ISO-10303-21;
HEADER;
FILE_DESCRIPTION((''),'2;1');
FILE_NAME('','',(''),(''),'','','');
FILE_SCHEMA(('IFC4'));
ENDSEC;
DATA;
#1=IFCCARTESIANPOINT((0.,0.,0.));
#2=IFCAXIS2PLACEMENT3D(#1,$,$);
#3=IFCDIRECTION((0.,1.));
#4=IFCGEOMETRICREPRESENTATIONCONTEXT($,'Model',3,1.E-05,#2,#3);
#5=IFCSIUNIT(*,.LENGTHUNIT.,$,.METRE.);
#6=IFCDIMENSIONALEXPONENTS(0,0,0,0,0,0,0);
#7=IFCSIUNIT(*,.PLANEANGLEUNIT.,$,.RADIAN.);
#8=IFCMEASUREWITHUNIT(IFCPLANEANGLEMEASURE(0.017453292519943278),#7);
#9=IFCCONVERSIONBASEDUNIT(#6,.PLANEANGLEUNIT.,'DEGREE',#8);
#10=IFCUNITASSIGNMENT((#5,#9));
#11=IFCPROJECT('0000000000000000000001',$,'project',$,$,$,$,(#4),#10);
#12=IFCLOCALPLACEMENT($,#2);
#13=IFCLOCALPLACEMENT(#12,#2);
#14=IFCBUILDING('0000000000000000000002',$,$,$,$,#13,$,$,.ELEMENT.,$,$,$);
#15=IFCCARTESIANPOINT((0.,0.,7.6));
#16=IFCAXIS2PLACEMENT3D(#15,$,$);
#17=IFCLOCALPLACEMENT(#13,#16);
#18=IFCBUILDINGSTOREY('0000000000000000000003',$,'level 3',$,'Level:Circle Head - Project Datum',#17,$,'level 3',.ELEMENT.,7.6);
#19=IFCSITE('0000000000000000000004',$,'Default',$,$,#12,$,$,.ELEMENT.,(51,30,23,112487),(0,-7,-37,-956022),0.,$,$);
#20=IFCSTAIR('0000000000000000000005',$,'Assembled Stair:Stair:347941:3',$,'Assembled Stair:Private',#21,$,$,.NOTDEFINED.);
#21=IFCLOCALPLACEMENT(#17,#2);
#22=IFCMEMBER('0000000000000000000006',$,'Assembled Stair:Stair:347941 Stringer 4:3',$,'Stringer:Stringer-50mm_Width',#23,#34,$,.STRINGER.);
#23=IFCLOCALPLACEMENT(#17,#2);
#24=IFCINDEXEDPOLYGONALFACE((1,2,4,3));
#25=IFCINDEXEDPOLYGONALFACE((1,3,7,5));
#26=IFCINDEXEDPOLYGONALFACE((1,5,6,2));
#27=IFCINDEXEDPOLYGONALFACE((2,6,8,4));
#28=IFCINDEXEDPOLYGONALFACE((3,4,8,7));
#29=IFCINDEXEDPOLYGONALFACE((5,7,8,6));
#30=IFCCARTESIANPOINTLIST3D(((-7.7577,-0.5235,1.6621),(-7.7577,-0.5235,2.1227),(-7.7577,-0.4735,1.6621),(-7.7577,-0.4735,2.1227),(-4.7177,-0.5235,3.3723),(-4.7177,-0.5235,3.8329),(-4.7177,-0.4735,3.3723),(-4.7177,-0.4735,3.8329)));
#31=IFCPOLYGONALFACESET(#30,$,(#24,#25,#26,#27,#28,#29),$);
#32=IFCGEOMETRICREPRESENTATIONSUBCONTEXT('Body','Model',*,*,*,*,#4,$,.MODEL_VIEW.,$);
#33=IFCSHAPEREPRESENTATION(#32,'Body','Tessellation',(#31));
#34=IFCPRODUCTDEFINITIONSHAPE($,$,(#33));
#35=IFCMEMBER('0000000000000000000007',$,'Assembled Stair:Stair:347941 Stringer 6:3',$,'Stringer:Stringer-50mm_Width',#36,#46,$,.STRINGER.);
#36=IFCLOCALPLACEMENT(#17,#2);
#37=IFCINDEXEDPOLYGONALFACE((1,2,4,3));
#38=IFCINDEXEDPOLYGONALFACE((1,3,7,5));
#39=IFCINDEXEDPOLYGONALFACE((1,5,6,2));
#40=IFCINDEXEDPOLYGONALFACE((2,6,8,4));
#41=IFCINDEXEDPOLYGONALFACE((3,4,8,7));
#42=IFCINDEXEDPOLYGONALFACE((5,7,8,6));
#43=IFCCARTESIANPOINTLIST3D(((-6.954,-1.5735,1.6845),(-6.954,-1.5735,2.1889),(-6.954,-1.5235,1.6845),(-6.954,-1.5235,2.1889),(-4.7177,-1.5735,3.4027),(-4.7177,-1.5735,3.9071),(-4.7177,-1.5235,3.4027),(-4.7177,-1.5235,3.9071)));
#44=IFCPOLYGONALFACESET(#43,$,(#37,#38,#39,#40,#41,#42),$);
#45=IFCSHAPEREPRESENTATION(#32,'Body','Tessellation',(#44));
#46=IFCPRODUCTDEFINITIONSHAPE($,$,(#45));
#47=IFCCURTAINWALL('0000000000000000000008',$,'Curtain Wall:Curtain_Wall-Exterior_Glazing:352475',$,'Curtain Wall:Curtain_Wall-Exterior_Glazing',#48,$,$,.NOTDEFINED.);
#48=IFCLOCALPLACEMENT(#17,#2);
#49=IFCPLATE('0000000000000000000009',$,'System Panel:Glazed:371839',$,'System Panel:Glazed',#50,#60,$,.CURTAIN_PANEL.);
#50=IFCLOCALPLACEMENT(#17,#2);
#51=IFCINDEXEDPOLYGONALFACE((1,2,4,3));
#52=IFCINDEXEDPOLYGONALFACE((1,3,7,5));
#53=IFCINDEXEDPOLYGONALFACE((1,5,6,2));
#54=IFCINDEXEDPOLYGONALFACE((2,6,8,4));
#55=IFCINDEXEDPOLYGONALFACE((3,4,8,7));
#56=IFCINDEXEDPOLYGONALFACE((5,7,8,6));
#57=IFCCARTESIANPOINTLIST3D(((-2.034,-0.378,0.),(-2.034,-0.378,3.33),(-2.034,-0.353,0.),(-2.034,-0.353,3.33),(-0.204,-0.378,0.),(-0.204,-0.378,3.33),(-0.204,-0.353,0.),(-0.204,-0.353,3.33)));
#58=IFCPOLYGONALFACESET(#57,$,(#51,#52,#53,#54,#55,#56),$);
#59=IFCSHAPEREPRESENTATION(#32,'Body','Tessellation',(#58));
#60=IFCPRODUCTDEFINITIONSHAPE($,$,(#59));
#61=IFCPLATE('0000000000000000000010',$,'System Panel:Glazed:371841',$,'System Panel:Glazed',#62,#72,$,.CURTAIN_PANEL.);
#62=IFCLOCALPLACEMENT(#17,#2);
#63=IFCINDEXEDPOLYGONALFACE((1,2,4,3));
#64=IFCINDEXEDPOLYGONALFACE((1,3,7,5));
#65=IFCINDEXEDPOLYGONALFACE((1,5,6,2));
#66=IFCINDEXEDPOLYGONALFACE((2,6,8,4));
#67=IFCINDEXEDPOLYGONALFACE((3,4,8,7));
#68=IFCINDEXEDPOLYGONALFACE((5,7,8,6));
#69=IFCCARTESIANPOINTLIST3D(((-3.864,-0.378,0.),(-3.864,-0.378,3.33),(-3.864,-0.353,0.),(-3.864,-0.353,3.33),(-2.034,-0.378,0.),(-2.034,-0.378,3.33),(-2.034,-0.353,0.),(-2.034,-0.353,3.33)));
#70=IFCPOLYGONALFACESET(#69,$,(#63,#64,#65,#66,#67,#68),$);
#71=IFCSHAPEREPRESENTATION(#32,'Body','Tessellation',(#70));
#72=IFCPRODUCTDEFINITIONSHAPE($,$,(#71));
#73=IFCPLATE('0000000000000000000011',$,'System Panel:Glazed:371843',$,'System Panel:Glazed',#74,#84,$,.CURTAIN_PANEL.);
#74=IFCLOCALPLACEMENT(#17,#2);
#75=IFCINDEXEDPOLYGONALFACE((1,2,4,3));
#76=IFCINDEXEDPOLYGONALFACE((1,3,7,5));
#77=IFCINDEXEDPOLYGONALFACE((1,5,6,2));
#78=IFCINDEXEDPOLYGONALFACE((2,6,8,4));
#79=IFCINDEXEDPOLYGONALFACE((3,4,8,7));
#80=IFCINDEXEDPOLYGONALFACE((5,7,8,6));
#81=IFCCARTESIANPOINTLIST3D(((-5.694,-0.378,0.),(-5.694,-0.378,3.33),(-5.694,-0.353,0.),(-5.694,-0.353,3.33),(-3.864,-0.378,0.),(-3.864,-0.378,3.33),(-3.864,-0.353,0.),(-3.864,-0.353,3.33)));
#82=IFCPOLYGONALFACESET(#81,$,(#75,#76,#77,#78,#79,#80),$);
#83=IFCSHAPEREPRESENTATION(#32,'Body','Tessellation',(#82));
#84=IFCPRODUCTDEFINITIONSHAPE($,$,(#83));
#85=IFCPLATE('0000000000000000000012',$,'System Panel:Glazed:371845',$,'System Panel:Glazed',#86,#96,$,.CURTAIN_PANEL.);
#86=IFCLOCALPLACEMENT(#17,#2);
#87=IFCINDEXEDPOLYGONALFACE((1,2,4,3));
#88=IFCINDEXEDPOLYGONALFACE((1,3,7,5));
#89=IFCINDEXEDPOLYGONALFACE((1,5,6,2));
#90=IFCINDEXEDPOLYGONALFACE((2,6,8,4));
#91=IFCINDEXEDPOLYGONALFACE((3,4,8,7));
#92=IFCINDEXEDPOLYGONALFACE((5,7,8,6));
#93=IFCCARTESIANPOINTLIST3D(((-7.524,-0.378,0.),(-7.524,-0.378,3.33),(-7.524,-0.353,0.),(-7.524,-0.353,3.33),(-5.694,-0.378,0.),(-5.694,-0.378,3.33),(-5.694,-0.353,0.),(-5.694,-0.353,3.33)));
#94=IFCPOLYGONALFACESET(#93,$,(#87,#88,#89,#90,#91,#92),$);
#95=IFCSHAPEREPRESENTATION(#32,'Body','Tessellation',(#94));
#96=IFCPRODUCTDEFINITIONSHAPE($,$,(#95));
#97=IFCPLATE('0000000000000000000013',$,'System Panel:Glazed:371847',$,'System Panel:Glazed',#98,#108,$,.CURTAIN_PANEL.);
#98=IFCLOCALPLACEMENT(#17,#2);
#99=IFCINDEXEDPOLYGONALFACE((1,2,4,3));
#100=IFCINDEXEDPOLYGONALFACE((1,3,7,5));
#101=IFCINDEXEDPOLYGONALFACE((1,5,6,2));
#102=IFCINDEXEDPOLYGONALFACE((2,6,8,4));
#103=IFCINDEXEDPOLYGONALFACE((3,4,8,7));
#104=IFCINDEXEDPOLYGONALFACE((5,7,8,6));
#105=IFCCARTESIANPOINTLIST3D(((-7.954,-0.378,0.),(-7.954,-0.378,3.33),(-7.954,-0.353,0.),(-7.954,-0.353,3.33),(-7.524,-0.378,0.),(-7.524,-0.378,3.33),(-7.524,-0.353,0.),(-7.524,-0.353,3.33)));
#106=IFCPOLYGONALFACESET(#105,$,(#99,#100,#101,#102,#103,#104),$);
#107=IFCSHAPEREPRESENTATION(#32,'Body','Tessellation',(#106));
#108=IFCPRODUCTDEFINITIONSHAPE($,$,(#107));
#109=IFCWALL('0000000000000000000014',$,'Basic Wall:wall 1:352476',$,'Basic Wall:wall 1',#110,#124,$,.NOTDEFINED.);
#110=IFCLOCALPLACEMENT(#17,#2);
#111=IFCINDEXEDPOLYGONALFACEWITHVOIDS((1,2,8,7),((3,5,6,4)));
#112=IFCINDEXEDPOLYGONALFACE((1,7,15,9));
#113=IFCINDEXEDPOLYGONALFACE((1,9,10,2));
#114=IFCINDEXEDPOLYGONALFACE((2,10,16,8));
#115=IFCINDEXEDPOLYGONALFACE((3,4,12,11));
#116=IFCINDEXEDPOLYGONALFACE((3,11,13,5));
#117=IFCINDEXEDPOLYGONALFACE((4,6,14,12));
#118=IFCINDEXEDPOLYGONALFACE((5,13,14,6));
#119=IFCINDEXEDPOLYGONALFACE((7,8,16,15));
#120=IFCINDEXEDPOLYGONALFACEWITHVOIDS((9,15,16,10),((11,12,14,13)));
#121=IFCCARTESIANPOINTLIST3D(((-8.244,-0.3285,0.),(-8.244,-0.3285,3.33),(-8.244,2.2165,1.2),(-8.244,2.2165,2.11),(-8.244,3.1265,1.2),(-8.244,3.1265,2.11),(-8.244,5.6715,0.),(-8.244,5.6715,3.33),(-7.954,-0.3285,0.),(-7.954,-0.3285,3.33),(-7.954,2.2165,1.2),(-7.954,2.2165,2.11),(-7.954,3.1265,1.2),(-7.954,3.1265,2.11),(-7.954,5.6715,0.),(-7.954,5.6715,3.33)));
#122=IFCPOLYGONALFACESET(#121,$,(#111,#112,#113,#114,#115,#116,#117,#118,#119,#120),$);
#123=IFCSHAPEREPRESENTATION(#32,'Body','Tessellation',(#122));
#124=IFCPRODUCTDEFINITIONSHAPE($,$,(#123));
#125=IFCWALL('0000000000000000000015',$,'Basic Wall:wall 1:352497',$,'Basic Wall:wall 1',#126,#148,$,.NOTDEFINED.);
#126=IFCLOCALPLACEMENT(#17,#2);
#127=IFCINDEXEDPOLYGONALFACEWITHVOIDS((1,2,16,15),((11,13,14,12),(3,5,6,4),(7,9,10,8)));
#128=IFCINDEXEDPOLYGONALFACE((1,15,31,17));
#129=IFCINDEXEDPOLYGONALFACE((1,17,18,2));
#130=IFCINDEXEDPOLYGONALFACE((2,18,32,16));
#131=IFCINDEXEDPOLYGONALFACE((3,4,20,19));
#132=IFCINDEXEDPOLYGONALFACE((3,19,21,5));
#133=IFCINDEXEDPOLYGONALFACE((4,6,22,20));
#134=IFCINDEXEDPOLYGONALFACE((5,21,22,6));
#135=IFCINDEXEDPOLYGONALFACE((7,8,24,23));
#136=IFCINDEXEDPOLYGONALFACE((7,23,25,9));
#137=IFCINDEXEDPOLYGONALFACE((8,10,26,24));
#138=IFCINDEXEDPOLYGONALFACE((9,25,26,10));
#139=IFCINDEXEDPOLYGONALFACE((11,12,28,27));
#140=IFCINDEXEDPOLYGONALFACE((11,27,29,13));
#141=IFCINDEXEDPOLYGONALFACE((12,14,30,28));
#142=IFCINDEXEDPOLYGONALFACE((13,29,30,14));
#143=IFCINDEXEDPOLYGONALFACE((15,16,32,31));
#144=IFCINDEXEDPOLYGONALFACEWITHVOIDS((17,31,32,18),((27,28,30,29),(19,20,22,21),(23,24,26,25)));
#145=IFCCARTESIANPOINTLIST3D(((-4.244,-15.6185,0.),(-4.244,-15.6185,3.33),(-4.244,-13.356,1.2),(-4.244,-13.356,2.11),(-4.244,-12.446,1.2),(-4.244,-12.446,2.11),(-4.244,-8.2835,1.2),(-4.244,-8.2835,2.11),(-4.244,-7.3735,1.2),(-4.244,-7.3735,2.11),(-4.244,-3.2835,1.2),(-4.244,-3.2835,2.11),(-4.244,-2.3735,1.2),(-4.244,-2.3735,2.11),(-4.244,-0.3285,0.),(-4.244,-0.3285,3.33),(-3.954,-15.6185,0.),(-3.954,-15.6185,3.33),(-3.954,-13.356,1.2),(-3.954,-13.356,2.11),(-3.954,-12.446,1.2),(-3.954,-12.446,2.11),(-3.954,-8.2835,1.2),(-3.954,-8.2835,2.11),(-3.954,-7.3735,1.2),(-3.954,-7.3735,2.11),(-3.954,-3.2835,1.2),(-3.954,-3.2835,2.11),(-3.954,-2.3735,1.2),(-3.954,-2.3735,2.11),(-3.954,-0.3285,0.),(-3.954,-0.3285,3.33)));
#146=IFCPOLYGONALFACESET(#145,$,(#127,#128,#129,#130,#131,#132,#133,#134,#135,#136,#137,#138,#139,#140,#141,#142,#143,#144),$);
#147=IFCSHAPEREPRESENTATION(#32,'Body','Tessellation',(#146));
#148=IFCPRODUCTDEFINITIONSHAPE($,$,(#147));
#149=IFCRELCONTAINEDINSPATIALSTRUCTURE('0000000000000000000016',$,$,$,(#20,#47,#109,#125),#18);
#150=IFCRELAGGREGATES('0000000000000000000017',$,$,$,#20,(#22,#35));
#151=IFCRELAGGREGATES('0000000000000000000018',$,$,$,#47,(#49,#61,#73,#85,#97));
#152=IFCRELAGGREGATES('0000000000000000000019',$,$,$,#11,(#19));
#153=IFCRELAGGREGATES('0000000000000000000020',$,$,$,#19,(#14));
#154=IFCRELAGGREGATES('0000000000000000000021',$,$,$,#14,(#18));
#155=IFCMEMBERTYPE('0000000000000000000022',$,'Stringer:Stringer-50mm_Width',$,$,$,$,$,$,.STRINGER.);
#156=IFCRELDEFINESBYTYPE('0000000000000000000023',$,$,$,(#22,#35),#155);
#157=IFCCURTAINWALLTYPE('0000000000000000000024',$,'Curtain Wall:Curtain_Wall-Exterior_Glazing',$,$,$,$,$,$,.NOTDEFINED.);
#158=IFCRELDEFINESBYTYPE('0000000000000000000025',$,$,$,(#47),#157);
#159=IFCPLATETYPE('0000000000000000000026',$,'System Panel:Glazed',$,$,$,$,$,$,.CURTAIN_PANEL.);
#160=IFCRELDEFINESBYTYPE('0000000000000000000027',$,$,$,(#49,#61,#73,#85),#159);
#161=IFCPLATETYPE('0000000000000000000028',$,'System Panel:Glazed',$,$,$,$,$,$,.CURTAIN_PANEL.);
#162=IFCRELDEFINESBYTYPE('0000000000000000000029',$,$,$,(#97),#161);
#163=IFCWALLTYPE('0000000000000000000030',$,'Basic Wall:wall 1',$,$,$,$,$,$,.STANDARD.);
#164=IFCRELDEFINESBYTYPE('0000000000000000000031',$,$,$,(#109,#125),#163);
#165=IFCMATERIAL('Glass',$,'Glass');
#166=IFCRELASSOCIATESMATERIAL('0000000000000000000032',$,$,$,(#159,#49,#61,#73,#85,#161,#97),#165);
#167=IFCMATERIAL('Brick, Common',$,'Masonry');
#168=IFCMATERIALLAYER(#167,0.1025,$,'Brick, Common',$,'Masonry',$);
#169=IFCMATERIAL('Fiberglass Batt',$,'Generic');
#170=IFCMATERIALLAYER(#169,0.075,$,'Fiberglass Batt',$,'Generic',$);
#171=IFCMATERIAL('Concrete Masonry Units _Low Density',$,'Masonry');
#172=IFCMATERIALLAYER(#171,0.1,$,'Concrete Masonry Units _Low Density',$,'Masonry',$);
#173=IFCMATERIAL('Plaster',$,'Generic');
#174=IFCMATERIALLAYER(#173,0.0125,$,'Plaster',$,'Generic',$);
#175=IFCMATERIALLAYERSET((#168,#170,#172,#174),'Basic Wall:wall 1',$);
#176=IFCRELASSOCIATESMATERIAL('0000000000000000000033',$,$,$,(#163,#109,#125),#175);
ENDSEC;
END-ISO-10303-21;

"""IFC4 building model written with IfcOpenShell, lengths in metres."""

from ifc_helpers import new_model, entity, si_unit, converted_unit, direction, frame, frame_2d, origin, origin_2d_with_axis, place, context, subcontext, project, spatial, polyline, rectangle, outline, extrude, clip, bounded_halfspace, source, transform, mapped, material, layer, layer_set, layer_usage, type_object, type_shapes, element, aggregate, save


model = new_model("IFC4")

# Units and contexts
model_context = context("Model", 3, precision=1e-05, world=origin(), true_north=direction((0.0, 1.0)))
body_context = subcontext(model_context, "Body", "Model", "MODEL_VIEW")
ifc_project = project(units=[si_unit("LENGTHUNIT", "METRE"), converted_unit("PLANEANGLEUNIT", "DEGREE", entity("IfcPlaneAngleMeasure", 0.017453292519943278), si_unit("PLANEANGLEUNIT", "RADIAN"), dimensions=[0, 0, 0, 0, 0, 0, 0])], contexts=[model_context])

# Site, building, storey
site_placement = place(None, origin())
site = spatial("IfcSite", under=ifc_project, at=site_placement, Name="Default", CompositionType="ELEMENT", RefLatitude=(51, 30, 23, 112487), RefLongitude=(0, -7, -37, -956022), RefElevation=0.0)
building_placement = place(site_placement, origin())
building = spatial("IfcBuilding", under=site, at=building_placement, CompositionType="ELEMENT")
storey_placement = place(building_placement, frame((0.0, 0.0, 7.6)))
storey = spatial("IfcBuildingStorey", under=building, at=storey_placement, Name="level 3", ObjectType="Level:Circle Head - Project Datum", LongName="level 3", CompositionType="ELEMENT", Elevation=7.6)

# Stair, members
stair_placement = place(storey_placement, origin())
stair = element("IfcStair", 1, at=stair_placement, inside=storey, Name="Assembled Stair:Stair:347941:3", ObjectType="Assembled Stair:Private", PredefinedType="NOTDEFINED")
member_type = type_object("IfcMemberType", Name="Stringer:Stringer-50mm_Width", PredefinedType="STRINGER")
member_1_placement = place(stair_placement, frame((-7.7577, -0.5235, 1.6621)))
member_1 = element("IfcMember", 2, at=member_1_placement, type_object=member_type, Name="Assembled Stair:Stair:347941 Stringer 4:3", ObjectType="Stringer:Stringer-50mm_Width", PredefinedType="STRINGER", context=body_context, shape_type="SweptSolid", body=[
    extrude(outline(polyline([(-1.6311, -0.2007), (1.857, -0.2007), (1.6311, 0.2007), (-1.857, 0.2007), (-1.6311, -0.2007)])), frame((1.52, 0.0, 1.0854), z_axis=(0.0, 1.0, 0.0), x_axis=(0.871553, 0.0, 0.490302)), (0.0, 0.0, 1.0), 0.05),
])
member_2_placement = place(stair_placement, frame((-6.954, -1.5735, 1.6845)))
member_2 = element("IfcMember", 3, at=member_2_placement, type_object=member_type, Name="Assembled Stair:Stair:347941 Stringer 6:3", ObjectType="Stringer:Stringer-50mm_Width", PredefinedType="STRINGER", context=body_context, shape_type="SweptSolid", body=[
    extrude(outline(polyline([(-1.2564, -0.2), (1.5637, -0.2), (1.2564, 0.2), (-1.5637, 0.2), (-1.2564, -0.2)])), frame((1.1182, 0.0, 1.1113), z_axis=(0.0, 1.0, 0.0), x_axis=(0.792984, 0.0, 0.609242)), (0.0, 0.0, 1.0), 0.05),
])
aggregate(stair, [member_1, member_2])

# Curtain wall, plates
curtain_wall_type = type_object("IfcCurtainWallType", Name="Curtain Wall:Curtain_Wall-Exterior_Glazing", PredefinedType="NOTDEFINED")
curtain_wall_placement = place(storey_placement, frame((0.0, 0.0, -7.6)))
curtain_wall = element("IfcCurtainWall", 4, at=curtain_wall_placement, inside=storey, type_object=curtain_wall_type, Name="Curtain Wall:Curtain_Wall-Exterior_Glazing:352475", ObjectType="Curtain Wall:Curtain_Wall-Exterior_Glazing", PredefinedType="NOTDEFINED")
ifc_material_1 = material(Name="Glass", Category="Glass")
plate_type_1 = type_object("IfcPlateType", Name="System Panel:Glazed", PredefinedType="CURTAIN_PANEL", material=ifc_material_1)
shared_shape_1 = source(origin(), body_context, "Body", "SweptSolid", [
    extrude(rectangle(XDim=0.025, YDim=1.83, at=origin_2d_with_axis()), frame((0.915, 0.0125, 0.0), z_axis=(0.0, 0.0, 1.0), x_axis=(0.0, 1.0, 0.0)), (0.0, 0.0, 1.0), 3.33),
])
type_shapes(plate_type_1, [shared_shape_1])
plate_1_placement = place(curtain_wall_placement, frame((-0.204, -0.353, 7.6), z_axis=(0.0, 0.0, 1.0), x_axis=(-1.0, 0.0, 0.0)))
plate_1 = element("IfcPlate", 5, at=plate_1_placement, type_object=plate_type_1, material=ifc_material_1, Name="System Panel:Glazed:371839", ObjectType="System Panel:Glazed", PredefinedType="CURTAIN_PANEL", context=body_context, shape_type="MappedRepresentation", body=[
    mapped(shared_shape_1, transform((0.0, 0.0, 0.0), scale=1.0)),
])
plate_2_placement = place(curtain_wall_placement, frame((-2.034, -0.353, 7.6), z_axis=(0.0, 0.0, 1.0), x_axis=(-1.0, 0.0, 0.0)))
plate_2 = element("IfcPlate", 6, at=plate_2_placement, type_object=plate_type_1, material=ifc_material_1, Name="System Panel:Glazed:371841", ObjectType="System Panel:Glazed", PredefinedType="CURTAIN_PANEL", context=body_context, shape_type="MappedRepresentation", body=[
    mapped(shared_shape_1, transform((0.0, 0.0, 0.0), scale=1.0)),
])
plate_3_placement = place(curtain_wall_placement, frame((-3.864, -0.353, 7.6), z_axis=(0.0, 0.0, 1.0), x_axis=(-1.0, 0.0, 0.0)))
plate_3 = element("IfcPlate", 7, at=plate_3_placement, type_object=plate_type_1, material=ifc_material_1, Name="System Panel:Glazed:371843", ObjectType="System Panel:Glazed", PredefinedType="CURTAIN_PANEL", context=body_context, shape_type="MappedRepresentation", body=[
    mapped(shared_shape_1, transform((0.0, 0.0, 0.0), scale=1.0)),
])
plate_4_placement = place(curtain_wall_placement, frame((-5.694, -0.353, 7.6), z_axis=(0.0, 0.0, 1.0), x_axis=(-1.0, 0.0, 0.0)))
plate_4 = element("IfcPlate", 8, at=plate_4_placement, type_object=plate_type_1, material=ifc_material_1, Name="System Panel:Glazed:371845", ObjectType="System Panel:Glazed", PredefinedType="CURTAIN_PANEL", context=body_context, shape_type="MappedRepresentation", body=[
    mapped(shared_shape_1, transform((0.0, 0.0, 0.0), scale=1.0)),
])
plate_type_2 = type_object("IfcPlateType", Name="System Panel:Glazed", PredefinedType="CURTAIN_PANEL", material=ifc_material_1)
shared_shape_2 = source(origin(), body_context, "Body", "SweptSolid", [
    extrude(rectangle(XDim=0.025, YDim=0.43, at=origin_2d_with_axis()), frame((0.215, 0.0125, 0.0), z_axis=(0.0, 0.0, 1.0), x_axis=(0.0, 1.0, 0.0)), (0.0, 0.0, 1.0), 3.33),
])
type_shapes(plate_type_2, [shared_shape_2])
plate_5_placement = place(curtain_wall_placement, frame((-7.524, -0.353, 7.6), z_axis=(0.0, 0.0, 1.0), x_axis=(-1.0, 0.0, 0.0)))
plate_5 = element("IfcPlate", 9, at=plate_5_placement, type_object=plate_type_2, material=ifc_material_1, Name="System Panel:Glazed:371847", ObjectType="System Panel:Glazed", PredefinedType="CURTAIN_PANEL", context=body_context, shape_type="MappedRepresentation", body=[
    mapped(shared_shape_2, transform((0.0, 0.0, 0.0), scale=1.0)),
])
aggregate(curtain_wall, [plate_1, plate_2, plate_3, plate_4, plate_5])

# Wall, opening
ifc_material_2 = material(Name="Brick, Common", Category="Masonry")
ifc_layer_1 = layer(ifc_material_2, 0.1025, Name="Brick, Common", Category="Masonry")
ifc_material_3 = material(Name="Fiberglass Batt", Category="Generic")
ifc_layer_2 = layer(ifc_material_3, 0.075, Name="Fiberglass Batt", Category="Generic")
ifc_material_4 = material(Name="Concrete Masonry Units _Low Density", Category="Masonry")
ifc_layer_3 = layer(ifc_material_4, 0.1, Name="Concrete Masonry Units _Low Density", Category="Masonry")
ifc_material_5 = material(Name="Plaster", Category="Generic")
ifc_layer_4 = layer(ifc_material_5, 0.0125, Name="Plaster", Category="Generic")
ifc_layer_set = layer_set([ifc_layer_1, ifc_layer_2, ifc_layer_3, ifc_layer_4], Name="Basic Wall:wall 1")
ifc_layer_usage_1 = layer_usage(ifc_layer_set, "AXIS2", "NEGATIVE", 0.145)
wall_type = type_object("IfcWallType", Name="Basic Wall:wall 1", PredefinedType="STANDARD", material=ifc_layer_set)
wall_1_placement = place(storey_placement, frame((-8.099, -0.3285, 0.0), z_axis=(0.0, 0.0, 1.0), x_axis=(0.0, 1.0, 0.0)))
wall_1 = element("IfcWall", 10, at=wall_1_placement, inside=storey, type_object=wall_type, material=ifc_layer_usage_1, Name="Basic Wall:wall 1:352476", ObjectType="Basic Wall:wall 1", PredefinedType="NOTDEFINED", context=body_context, shape_type="Clipping", body=[
    clip(extrude(rectangle(XDim=6.0, YDim=0.29, at=frame_2d((3.0, 0.0), x_axis=(-1.0, 0.0))), origin(), (0.0, 0.0, 1.0), 3.33), bounded_halfspace(frame((0.0, -0.145, 3.33), z_axis=(0.0, 0.0, -1.0), x_axis=(1.0, 0.0, 0.0)), True, frame((0.0, -0.145, 3.33)), polyline([(0.0, 0.0), (6.0, 0.0), (6.0, 0.29), (0.0, 0.29), (0.0, 0.0)]))),
])
opening_1_placement = place(wall_1_placement, frame((2.545, -0.145, 1.2)))
element("IfcOpeningElement", 11, at=opening_1_placement, cuts=wall_1, PredefinedType="OPENING", context=body_context, shape_type="SweptSolid", body=[
    extrude(rectangle(XDim=0.91, YDim=0.91, at=frame_2d((0.455, 0.455), x_axis=(-1.0, 0.0))), frame((0.0, 0.0, 0.0), z_axis=(0.0, 1.0, 0.0), x_axis=(0.0, 0.0, 1.0)), (0.0, 0.0, 1.0), 0.29),
])

# Wall, openings
ifc_layer_usage_2 = layer_usage(ifc_layer_set, "AXIS2", "NEGATIVE", 0.145)
wall_2_placement = place(storey_placement, frame((-4.099, -0.3285, 0.0), z_axis=(0.0, 0.0, 1.0), x_axis=(0.0, -1.0, 0.0)))
wall_2 = element("IfcWall", 12, at=wall_2_placement, inside=storey, type_object=wall_type, material=ifc_layer_usage_2, Name="Basic Wall:wall 1:352497", ObjectType="Basic Wall:wall 1", PredefinedType="NOTDEFINED", context=body_context, shape_type="Clipping", body=[
    clip(extrude(rectangle(XDim=15.29, YDim=0.29, at=frame_2d((7.645, 0.0), x_axis=(-1.0, 0.0))), origin(), (0.0, 0.0, 1.0), 3.33), bounded_halfspace(frame((0.0, -0.145, 3.33), z_axis=(0.0, 0.0, -1.0), x_axis=(-1.0, 0.0, 0.0)), True, frame((0.0, -0.145, 3.33)), polyline([(0.0, 0.0), (4.9375, 0.0), (5.0625, 0.0), (9.9375, 0.0), (10.0625, 0.0), (15.0, 0.0), (15.29, 0.0), (15.29, 0.29), (0.0, 0.29), (0.0, 0.0)]))),
])
opening_2_placement = place(wall_2_placement, frame((-0.3285, 4.099, 0.0)))
element("IfcOpeningElement", 13, at=opening_2_placement, cuts=wall_2, PredefinedType="OPENING", context=body_context, shape_type="SweptSolid", body=[
    extrude(rectangle(XDim=2.11, YDim=0.125, at=frame_2d((0.0, 0.0), x_axis=(0.0, 1.0))), frame((5.3285, -5.054, 1.055), z_axis=(0.0, 1.0, 0.0), x_axis=(1.0, 0.0, 0.0)), (0.0, 0.0, 1.0), 0.81),
])
opening_3_placement = place(wall_2_placement, frame((12.1175, -0.145, 1.2)))
element("IfcOpeningElement", 14, at=opening_3_placement, cuts=wall_2, PredefinedType="OPENING", context=body_context, shape_type="SweptSolid", body=[
    extrude(rectangle(XDim=0.91, YDim=0.91, at=frame_2d((0.455, 0.455), x_axis=(-1.0, 0.0))), frame((0.0, 0.0, 0.0), z_axis=(0.0, 1.0, 0.0), x_axis=(0.0, 0.0, 1.0)), (0.0, 0.0, 1.0), 0.29),
])
opening_4_placement = place(wall_2_placement, frame((2.045, -0.145, 1.2)))
element("IfcOpeningElement", 15, at=opening_4_placement, cuts=wall_2, PredefinedType="OPENING", context=body_context, shape_type="SweptSolid", body=[
    extrude(rectangle(XDim=0.91, YDim=0.91, at=frame_2d((0.455, 0.455), x_axis=(-1.0, 0.0))), frame((0.0, 0.0, 0.0), z_axis=(0.0, 1.0, 0.0), x_axis=(0.0, 0.0, 1.0)), (0.0, 0.0, 1.0), 0.29),
])
opening_5_placement = place(wall_2_placement, frame((7.045, -0.145, 1.2)))
element("IfcOpeningElement", 16, at=opening_5_placement, cuts=wall_2, PredefinedType="OPENING", context=body_context, shape_type="SweptSolid", body=[
    extrude(rectangle(XDim=0.91, YDim=0.91, at=frame_2d((0.455, 0.455), x_axis=(-1.0, 0.0))), frame((0.0, 0.0, 0.0), z_axis=(0.0, 1.0, 0.0), x_axis=(0.0, 0.0, 1.0)), (0.0, 0.0, 1.0), 0.29),
])

save(model, "model.ifc")
